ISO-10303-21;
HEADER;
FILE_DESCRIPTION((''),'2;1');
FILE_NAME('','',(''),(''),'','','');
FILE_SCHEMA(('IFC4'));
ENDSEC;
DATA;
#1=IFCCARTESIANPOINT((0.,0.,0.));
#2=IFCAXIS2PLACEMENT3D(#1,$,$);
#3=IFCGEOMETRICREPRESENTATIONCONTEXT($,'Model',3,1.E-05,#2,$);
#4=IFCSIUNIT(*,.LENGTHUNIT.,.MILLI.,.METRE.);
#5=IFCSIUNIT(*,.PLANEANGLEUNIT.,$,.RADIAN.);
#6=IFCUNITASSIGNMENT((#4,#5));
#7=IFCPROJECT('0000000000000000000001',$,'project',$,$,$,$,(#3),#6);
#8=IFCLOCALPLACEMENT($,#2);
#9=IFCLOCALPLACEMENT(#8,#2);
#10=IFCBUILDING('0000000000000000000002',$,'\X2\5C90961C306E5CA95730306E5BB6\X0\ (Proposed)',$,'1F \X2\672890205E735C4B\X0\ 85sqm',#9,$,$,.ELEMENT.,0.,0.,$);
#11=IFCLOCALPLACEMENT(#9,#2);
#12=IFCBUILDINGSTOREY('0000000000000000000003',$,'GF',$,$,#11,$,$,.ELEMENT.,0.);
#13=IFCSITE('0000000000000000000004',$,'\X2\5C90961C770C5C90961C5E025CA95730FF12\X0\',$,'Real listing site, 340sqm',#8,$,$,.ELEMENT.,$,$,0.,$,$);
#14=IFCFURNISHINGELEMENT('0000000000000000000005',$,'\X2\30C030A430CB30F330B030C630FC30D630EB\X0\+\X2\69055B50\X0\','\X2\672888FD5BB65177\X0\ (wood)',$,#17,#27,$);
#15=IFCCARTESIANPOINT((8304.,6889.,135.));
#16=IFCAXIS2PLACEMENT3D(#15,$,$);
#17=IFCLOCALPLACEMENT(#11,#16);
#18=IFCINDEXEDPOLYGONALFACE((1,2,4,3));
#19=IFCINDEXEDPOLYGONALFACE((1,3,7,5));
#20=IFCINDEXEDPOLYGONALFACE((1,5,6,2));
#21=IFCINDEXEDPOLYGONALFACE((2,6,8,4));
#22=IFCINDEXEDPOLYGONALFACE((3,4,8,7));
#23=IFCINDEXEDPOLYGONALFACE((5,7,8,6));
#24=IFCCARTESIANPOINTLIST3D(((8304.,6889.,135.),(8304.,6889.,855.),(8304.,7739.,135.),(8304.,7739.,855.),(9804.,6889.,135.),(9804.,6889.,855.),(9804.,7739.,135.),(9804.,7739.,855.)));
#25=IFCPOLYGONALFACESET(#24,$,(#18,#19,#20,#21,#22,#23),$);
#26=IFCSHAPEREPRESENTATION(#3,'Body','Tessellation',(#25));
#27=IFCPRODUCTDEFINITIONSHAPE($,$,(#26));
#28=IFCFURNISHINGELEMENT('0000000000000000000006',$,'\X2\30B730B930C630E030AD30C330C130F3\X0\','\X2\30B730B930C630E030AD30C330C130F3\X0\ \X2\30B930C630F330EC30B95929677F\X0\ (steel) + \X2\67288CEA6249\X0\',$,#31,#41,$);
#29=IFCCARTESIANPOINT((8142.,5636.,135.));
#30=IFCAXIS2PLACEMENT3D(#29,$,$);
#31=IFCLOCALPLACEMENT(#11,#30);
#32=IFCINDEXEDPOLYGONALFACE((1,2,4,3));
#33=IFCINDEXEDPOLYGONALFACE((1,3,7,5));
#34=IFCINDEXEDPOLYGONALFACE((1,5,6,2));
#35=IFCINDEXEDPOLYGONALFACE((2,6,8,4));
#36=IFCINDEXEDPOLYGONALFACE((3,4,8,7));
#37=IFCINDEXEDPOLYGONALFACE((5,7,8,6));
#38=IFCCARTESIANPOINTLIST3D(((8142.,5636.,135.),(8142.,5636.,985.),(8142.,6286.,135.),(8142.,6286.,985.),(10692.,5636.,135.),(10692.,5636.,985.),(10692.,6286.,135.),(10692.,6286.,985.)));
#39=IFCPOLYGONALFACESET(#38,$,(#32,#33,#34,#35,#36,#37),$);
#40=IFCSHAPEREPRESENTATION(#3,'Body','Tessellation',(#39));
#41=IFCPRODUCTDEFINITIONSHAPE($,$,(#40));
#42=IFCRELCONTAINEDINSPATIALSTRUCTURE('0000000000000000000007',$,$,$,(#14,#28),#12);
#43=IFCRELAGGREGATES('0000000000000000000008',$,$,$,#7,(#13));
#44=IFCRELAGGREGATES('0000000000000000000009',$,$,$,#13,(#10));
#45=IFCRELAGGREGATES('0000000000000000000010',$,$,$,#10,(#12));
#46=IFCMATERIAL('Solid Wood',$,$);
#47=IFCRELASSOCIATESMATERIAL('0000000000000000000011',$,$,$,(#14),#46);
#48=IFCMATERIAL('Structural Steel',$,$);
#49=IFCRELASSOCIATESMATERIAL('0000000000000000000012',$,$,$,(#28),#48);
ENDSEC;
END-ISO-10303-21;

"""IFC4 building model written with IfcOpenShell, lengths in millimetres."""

from ifc_helpers import new_model, si_unit, frame, frame_2d, origin, place, context, project, spatial, rectangle, extrude, material, element, save


model = new_model("IFC4")

# Units and contexts
model_context = context("Model", 3, precision=1e-05, world=origin())
ifc_project = project(units=[si_unit("LENGTHUNIT", "METRE", prefix="MILLI"), si_unit("PLANEANGLEUNIT", "RADIAN")], contexts=[model_context])

# Site, building, storey
site_placement = place(None, origin())
site = spatial("IfcSite", under=ifc_project, at=site_placement, Name="岐阜県岐阜市岩地２", ObjectType="Real listing site, 340sqm", CompositionType="ELEMENT", RefElevation=0.0)
building_placement = place(site_placement, origin())
building = spatial("IfcBuilding", under=site, at=building_placement, Name="岐阜の岩地の家 (Proposed)", ObjectType="1F 木造平屋 85sqm", CompositionType="ELEMENT", ElevationOfRefHeight=0.0, ElevationOfTerrain=0.0)
storey_placement = place(building_placement, origin())
storey = spatial("IfcBuildingStorey", under=building, at=storey_placement, Name="GF", CompositionType="ELEMENT", Elevation=0.0)

# Shared definitions
ifc_material_1 = material(Name="Solid Wood")

# Shared definitions
ifc_material_2 = material(Name="Structural Steel")

# Furnishing elements
furnishing_1_placement = place(storey_placement, frame((8304.0, 6889.0, 135.0)))
element("IfcFurnishingElement", 1, at=furnishing_1_placement, inside=storey, material=ifc_material_1, Name="ダイニングテーブル+椅子", Description="木製家具 (wood)", context=model_context, shape_type="SweptSolid", body=[
    extrude(rectangle(XDim=1500.0, YDim=850.0, at=frame_2d((750.0, 425.0))), frame((8304.0, 6889.0, 135.0)), (0.0, 0.0, 1.0), 720.0),
])
furnishing_2_placement = place(storey_placement, frame((8142.0, 5636.0, 135.0)))
element("IfcFurnishingElement", 2, at=furnishing_2_placement, inside=storey, material=ifc_material_2, Name="システムキッチン", Description="システムキッチン ステンレス天板 (steel) + 木質扉", context=model_context, shape_type="SweptSolid", body=[
    extrude(rectangle(XDim=2550.0, YDim=650.0, at=frame_2d((1275.0, 325.0))), frame((8142.0, 5636.0, 135.0)), (0.0, 0.0, 1.0), 850.0),
])

save(model, "model.ifc")
